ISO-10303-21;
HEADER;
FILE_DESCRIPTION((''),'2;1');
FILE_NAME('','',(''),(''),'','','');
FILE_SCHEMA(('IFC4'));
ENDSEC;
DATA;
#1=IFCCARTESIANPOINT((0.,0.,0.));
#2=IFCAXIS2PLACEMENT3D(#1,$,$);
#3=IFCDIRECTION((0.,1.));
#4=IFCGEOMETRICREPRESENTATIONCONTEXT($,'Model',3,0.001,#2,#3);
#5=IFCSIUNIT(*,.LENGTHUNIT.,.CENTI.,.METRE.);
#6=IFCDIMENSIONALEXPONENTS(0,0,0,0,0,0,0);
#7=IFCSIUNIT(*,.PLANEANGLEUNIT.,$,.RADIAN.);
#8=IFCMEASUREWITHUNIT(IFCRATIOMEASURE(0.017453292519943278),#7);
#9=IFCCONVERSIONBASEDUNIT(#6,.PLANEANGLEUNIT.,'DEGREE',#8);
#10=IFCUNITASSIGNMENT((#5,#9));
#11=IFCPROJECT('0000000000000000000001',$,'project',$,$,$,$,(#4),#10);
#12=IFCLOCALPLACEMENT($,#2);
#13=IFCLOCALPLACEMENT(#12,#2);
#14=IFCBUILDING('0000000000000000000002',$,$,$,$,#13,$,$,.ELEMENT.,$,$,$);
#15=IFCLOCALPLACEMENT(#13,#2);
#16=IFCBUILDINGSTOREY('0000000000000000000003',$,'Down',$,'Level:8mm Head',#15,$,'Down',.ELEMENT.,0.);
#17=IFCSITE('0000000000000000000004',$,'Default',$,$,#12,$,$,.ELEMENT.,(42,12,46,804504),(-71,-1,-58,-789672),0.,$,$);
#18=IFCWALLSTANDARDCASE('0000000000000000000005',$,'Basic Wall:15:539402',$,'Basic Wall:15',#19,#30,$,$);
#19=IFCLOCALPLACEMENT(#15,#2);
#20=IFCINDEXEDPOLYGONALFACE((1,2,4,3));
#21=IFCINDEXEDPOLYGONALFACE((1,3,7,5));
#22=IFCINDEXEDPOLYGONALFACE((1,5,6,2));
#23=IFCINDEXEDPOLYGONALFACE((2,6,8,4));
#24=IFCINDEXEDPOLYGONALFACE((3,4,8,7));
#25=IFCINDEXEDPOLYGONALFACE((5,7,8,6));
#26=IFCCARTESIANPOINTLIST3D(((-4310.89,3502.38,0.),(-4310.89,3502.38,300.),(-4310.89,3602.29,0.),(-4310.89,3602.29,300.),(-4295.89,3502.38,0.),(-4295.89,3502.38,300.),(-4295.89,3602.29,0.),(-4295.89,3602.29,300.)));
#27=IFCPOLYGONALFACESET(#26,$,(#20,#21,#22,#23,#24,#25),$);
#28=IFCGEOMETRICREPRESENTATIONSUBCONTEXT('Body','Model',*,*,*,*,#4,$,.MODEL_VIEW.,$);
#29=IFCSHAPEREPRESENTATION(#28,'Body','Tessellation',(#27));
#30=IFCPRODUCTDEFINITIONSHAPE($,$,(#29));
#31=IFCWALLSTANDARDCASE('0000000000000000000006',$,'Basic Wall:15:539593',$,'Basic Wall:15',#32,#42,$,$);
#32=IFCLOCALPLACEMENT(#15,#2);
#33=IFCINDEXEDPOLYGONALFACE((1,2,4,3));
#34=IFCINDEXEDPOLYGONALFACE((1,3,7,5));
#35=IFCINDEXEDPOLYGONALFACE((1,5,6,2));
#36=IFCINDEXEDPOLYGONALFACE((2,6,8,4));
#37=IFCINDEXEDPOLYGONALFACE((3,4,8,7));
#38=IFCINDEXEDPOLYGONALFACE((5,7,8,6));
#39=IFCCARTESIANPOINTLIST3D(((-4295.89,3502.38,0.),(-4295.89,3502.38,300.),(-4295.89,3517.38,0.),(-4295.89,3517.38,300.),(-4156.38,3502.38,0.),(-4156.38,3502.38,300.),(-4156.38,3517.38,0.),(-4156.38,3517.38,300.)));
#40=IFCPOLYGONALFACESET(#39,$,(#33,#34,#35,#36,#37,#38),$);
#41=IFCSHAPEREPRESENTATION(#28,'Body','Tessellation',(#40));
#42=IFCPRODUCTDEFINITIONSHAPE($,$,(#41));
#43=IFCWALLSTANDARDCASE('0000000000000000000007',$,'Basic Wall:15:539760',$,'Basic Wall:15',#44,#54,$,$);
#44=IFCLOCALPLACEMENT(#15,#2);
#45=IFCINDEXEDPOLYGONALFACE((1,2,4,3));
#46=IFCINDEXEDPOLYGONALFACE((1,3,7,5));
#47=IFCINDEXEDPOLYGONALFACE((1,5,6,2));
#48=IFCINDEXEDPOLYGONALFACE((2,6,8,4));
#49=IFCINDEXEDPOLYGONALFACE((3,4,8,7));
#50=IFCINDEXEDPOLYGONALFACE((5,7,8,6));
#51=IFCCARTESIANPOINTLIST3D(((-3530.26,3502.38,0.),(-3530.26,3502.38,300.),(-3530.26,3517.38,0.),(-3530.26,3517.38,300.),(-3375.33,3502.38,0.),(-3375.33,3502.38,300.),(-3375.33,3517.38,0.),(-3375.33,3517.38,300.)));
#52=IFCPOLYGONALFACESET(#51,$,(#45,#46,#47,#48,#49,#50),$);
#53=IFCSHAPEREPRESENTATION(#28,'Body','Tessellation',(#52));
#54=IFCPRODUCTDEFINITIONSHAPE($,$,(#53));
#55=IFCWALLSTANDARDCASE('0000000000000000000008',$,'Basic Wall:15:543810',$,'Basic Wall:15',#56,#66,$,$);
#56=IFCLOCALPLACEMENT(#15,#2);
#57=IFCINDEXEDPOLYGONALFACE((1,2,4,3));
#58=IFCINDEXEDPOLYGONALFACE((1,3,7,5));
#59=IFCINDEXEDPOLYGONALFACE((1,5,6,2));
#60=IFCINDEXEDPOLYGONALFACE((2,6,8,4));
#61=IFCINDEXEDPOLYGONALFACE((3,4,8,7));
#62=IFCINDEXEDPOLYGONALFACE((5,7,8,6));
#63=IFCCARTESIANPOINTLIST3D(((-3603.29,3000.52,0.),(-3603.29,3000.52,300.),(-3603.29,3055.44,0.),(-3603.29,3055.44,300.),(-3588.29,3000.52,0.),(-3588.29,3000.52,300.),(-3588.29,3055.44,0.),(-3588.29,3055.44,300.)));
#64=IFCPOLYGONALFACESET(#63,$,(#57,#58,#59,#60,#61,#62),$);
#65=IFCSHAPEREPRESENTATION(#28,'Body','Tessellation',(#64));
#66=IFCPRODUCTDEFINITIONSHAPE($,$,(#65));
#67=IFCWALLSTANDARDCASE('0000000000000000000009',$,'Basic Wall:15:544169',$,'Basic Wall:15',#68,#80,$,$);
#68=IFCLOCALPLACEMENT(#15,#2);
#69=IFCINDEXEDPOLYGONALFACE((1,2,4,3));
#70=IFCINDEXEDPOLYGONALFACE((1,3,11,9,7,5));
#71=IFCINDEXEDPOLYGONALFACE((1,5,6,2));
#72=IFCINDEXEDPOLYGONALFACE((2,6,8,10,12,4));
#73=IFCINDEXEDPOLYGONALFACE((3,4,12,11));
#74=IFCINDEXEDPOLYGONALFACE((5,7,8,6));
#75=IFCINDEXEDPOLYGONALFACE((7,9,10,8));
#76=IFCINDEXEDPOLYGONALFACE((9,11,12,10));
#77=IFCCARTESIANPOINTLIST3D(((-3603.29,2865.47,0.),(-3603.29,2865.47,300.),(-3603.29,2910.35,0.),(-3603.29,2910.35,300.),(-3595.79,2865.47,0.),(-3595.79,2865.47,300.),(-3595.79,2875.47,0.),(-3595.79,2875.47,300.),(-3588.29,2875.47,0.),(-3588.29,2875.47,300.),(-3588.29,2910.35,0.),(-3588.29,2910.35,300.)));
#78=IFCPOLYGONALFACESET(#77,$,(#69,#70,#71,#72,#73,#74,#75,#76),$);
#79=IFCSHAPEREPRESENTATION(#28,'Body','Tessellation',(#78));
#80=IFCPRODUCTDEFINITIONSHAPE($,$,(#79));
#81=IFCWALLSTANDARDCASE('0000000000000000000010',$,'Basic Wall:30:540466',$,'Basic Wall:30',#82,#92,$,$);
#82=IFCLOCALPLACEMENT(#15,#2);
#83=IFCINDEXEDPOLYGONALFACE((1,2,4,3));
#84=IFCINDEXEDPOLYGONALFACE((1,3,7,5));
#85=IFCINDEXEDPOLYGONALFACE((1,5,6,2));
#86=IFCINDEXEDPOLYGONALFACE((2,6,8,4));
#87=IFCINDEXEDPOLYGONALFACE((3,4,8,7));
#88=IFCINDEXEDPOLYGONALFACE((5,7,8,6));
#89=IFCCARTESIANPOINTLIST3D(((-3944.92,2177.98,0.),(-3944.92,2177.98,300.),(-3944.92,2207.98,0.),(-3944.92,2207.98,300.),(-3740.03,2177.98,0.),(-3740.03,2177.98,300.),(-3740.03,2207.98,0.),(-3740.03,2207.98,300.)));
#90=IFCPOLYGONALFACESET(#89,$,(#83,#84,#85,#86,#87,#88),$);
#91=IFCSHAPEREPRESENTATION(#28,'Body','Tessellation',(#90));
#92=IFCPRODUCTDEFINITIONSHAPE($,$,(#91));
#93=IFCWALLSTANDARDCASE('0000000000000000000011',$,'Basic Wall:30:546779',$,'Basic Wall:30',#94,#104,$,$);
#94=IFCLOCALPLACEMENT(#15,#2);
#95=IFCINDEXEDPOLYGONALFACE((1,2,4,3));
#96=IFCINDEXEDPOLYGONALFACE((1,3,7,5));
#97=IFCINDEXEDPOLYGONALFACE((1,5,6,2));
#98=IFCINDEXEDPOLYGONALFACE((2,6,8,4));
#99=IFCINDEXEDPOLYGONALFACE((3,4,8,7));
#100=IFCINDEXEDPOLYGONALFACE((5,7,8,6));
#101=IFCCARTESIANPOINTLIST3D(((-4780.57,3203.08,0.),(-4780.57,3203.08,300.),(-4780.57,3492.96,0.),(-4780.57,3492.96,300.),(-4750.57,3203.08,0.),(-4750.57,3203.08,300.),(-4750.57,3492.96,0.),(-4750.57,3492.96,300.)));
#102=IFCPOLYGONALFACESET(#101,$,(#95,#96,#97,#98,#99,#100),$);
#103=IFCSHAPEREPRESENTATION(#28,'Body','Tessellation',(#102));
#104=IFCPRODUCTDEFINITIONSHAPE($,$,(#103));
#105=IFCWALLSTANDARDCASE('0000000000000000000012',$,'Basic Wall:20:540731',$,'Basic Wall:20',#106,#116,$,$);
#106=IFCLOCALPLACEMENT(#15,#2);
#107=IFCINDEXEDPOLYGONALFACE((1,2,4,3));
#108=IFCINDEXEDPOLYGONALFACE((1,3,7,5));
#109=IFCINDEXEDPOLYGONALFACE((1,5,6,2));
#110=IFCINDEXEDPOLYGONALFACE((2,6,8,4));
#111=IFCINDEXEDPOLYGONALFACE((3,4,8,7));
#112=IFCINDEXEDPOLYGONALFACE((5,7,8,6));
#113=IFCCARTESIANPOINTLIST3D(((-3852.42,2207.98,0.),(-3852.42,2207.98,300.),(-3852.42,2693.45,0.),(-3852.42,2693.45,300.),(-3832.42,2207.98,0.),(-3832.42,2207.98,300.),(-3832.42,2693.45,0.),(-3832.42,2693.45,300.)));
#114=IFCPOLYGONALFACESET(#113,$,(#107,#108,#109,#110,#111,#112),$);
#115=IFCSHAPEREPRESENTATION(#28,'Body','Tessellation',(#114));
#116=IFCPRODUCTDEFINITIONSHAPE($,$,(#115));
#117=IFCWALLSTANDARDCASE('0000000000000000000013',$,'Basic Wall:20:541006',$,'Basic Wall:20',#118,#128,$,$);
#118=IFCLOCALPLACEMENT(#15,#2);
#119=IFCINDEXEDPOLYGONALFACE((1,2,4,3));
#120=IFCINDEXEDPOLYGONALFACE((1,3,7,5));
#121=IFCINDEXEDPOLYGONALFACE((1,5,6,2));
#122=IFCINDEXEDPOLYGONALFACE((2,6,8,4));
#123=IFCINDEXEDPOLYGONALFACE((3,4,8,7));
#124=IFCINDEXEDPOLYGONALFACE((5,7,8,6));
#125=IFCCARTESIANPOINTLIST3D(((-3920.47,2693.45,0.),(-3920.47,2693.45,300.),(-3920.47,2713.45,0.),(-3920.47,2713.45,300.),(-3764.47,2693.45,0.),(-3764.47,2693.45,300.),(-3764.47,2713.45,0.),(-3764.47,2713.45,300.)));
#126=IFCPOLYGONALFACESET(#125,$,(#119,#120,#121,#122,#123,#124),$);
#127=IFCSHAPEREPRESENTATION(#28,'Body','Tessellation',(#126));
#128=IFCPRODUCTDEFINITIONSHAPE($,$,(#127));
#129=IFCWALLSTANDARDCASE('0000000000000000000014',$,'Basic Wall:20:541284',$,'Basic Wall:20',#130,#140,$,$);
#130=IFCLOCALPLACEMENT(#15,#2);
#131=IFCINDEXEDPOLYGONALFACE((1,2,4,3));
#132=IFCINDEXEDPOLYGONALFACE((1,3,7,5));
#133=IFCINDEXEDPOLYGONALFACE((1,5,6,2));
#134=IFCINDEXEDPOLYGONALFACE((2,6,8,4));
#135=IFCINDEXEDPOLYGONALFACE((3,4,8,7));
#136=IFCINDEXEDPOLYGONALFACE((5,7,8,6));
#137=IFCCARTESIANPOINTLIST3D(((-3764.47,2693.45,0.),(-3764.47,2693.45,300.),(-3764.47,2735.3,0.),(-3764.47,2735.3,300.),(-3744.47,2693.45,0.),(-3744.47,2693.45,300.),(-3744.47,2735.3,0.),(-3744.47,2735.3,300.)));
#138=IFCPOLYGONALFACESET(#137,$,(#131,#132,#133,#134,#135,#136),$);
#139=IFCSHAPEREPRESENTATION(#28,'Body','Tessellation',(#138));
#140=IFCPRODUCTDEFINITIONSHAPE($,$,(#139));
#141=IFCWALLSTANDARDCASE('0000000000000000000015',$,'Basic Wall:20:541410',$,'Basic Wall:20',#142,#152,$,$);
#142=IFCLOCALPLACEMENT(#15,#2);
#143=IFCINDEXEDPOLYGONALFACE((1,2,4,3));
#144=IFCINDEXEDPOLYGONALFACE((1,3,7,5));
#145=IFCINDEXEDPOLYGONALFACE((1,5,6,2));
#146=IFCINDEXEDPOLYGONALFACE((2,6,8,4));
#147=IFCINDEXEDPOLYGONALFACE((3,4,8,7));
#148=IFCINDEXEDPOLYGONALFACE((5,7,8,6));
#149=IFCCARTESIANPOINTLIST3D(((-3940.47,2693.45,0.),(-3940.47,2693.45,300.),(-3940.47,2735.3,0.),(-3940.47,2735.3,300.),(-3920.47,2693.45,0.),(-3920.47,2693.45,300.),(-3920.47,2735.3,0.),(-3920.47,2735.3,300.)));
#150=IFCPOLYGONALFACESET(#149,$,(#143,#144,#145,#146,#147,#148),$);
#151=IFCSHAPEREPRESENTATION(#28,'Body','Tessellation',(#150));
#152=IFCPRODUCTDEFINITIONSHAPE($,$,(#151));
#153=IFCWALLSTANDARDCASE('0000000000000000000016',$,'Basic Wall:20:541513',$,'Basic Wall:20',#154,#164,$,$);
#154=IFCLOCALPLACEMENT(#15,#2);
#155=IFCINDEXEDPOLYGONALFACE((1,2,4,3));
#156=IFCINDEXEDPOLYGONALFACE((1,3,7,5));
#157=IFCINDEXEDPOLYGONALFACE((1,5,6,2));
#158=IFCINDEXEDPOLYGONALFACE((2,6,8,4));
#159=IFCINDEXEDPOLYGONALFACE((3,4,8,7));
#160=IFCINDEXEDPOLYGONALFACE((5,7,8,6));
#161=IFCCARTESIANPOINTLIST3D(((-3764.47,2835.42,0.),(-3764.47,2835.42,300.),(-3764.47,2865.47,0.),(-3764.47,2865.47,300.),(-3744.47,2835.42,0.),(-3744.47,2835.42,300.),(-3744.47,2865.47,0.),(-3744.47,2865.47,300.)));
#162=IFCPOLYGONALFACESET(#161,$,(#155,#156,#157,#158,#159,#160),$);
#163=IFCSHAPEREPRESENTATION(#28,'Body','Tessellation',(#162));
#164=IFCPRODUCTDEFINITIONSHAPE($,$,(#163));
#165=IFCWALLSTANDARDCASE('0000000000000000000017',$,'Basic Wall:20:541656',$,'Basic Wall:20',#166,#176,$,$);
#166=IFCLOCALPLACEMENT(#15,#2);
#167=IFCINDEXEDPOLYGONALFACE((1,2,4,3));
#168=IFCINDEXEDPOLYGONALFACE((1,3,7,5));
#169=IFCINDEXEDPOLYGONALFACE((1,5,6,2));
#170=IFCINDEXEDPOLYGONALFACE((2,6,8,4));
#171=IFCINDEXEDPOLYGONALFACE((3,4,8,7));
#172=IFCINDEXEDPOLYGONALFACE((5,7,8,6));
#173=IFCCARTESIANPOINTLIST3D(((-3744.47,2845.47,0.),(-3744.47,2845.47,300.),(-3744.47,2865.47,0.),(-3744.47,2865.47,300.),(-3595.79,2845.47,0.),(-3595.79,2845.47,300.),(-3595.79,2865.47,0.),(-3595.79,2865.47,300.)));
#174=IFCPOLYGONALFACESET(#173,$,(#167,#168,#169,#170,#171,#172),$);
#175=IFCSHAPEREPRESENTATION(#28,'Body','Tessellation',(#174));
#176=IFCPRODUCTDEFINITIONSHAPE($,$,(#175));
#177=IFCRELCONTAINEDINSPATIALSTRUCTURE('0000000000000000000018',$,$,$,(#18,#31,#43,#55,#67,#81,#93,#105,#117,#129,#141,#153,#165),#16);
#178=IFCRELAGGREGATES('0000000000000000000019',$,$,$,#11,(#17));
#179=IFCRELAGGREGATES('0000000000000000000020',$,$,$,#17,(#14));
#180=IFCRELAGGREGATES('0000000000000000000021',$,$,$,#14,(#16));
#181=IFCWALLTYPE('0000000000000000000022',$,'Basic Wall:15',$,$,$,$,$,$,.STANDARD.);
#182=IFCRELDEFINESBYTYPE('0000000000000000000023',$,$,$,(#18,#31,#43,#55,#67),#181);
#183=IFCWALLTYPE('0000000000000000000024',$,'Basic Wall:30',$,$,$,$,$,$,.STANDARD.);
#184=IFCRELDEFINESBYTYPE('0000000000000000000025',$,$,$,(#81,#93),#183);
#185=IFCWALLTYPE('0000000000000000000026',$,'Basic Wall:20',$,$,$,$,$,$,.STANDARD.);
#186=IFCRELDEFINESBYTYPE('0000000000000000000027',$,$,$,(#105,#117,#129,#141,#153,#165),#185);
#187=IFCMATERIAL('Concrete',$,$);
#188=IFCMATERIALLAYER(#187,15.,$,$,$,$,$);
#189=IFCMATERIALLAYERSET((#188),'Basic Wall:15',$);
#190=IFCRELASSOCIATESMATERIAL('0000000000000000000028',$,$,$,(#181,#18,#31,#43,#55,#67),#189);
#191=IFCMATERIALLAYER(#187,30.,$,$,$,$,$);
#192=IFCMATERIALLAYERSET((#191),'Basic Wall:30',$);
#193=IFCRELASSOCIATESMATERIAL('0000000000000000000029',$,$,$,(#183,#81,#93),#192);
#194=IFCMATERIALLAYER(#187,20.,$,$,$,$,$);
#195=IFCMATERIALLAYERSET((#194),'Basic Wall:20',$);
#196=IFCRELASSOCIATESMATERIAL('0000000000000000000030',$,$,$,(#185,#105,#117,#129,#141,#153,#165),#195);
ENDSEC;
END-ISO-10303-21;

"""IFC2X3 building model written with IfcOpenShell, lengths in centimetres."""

from ifc_helpers import new_model, entity, si_unit, converted_unit, direction, frame, frame_2d, origin, place, context, subcontext, project, spatial, polyline, rectangle, outline, extrude, material, layer, layer_set, layer_usage, type_object, element, save


model = new_model("IFC2X3")

# Units and contexts
model_context = context("Model", 3, precision=0.001, world=origin(), true_north=direction((0.0, 1.0)))
body_context = subcontext(model_context, "Body", "Model", "MODEL_VIEW")
ifc_project = project(units=[si_unit("LENGTHUNIT", "METRE", prefix="CENTI"), converted_unit("PLANEANGLEUNIT", "DEGREE", entity("IfcRatioMeasure", 0.017453292519943278), si_unit("PLANEANGLEUNIT", "RADIAN"), dimensions=[0, 0, 0, 0, 0, 0, 0])], contexts=[model_context])

# Site, building, storey
site_placement = place(None, origin())
site = spatial("IfcSite", under=ifc_project, at=site_placement, Name="Default", CompositionType="ELEMENT", RefLatitude=(42, 12, 46, 804504), RefLongitude=(-71, -1, -58, -789672), RefElevation=0.0)
building_placement = place(site_placement, origin())
building = spatial("IfcBuilding", under=site, at=building_placement, CompositionType="ELEMENT")
storey_placement = place(building_placement, origin())
storey = spatial("IfcBuildingStorey", under=building, at=storey_placement, Name="Down", ObjectType="Level:8mm Head", LongName="Down", CompositionType="ELEMENT", Elevation=0.0)

# Walls
ifc_material = material(Name="Concrete")
ifc_layer_1 = layer(ifc_material, 15.0)
ifc_layer_set_1 = layer_set([ifc_layer_1], Name="Basic Wall:15")
ifc_layer_usage_1 = layer_usage(ifc_layer_set_1, "AXIS2", "POSITIVE", -7.5)
wall_type_1 = type_object("IfcWallType", Name="Basic Wall:15", PredefinedType="STANDARD", material=ifc_layer_set_1)
wall_1_placement = place(storey_placement, frame((-4303.39, 3602.29, 0.0), z_axis=(0.0, 0.0, 1.0), x_axis=(0.0, -1.0, 0.0)))
element("IfcWallStandardCase", 1, at=wall_1_placement, inside=storey, type_object=wall_type_1, material=ifc_layer_usage_1, Name="Basic Wall:15:539402", ObjectType="Basic Wall:15", context=body_context, shape_type="SweptSolid", body=[
    extrude(rectangle(XDim=99.91, YDim=15.0, at=frame_2d((49.95, 0.0), x_axis=(-1.0, 0.0))), origin(), (0.0, 0.0, 1.0), 300.0),
])
ifc_layer_usage_2 = layer_usage(ifc_layer_set_1, "AXIS2", "POSITIVE", -7.5)
wall_2_placement = place(storey_placement, frame((-4295.89, 3509.88, 0.0)))
element("IfcWallStandardCase", 2, at=wall_2_placement, inside=storey, type_object=wall_type_1, material=ifc_layer_usage_2, Name="Basic Wall:15:539593", ObjectType="Basic Wall:15", context=body_context, shape_type="SweptSolid", body=[
    extrude(rectangle(XDim=139.51, YDim=15.0, at=frame_2d((69.76, 0.0), x_axis=(-1.0, 0.0))), origin(), (0.0, 0.0, 1.0), 300.0),
])
ifc_layer_usage_3 = layer_usage(ifc_layer_set_1, "AXIS2", "POSITIVE", -7.5)
wall_3_placement = place(storey_placement, frame((-3530.26, 3509.88, 0.0)))
element("IfcWallStandardCase", 3, at=wall_3_placement, inside=storey, type_object=wall_type_1, material=ifc_layer_usage_3, Name="Basic Wall:15:539760", ObjectType="Basic Wall:15", context=body_context, shape_type="SweptSolid", body=[
    extrude(rectangle(XDim=154.94, YDim=15.0, at=frame_2d((77.47, 0.0), x_axis=(-1.0, 0.0))), origin(), (0.0, 0.0, 1.0), 300.0),
])
ifc_layer_usage_4 = layer_usage(ifc_layer_set_1, "AXIS2", "POSITIVE", -7.5)
wall_4_placement = place(storey_placement, frame((-3595.79, 3055.44, 0.0), z_axis=(0.0, 0.0, 1.0), x_axis=(0.0, -1.0, 0.0)))
element("IfcWallStandardCase", 4, at=wall_4_placement, inside=storey, type_object=wall_type_1, material=ifc_layer_usage_4, Name="Basic Wall:15:543810", ObjectType="Basic Wall:15", context=body_context, shape_type="SweptSolid", body=[
    extrude(rectangle(XDim=54.93, YDim=15.0, at=frame_2d((27.46, 0.0), x_axis=(-1.0, 0.0))), origin(), (0.0, 0.0, 1.0), 300.0),
])
ifc_layer_usage_5 = layer_usage(ifc_layer_set_1, "AXIS2", "POSITIVE", -7.5)
wall_5_placement = place(storey_placement, frame((-3595.79, 2910.35, 0.0), z_axis=(0.0, 0.0, 1.0), x_axis=(0.0, -1.0, 0.0)))
element("IfcWallStandardCase", 5, at=wall_5_placement, inside=storey, type_object=wall_type_1, material=ifc_layer_usage_5, Name="Basic Wall:15:544169", ObjectType="Basic Wall:15", context=body_context, shape_type="SweptSolid", body=[
    extrude(outline(polyline([(44.87, -7.5), (44.87, 0.0), (34.87, 0.0), (34.87, 7.5), (0.0, 7.5), (0.0, -7.5), (44.87, -7.5)])), origin(), (0.0, 0.0, 1.0), 300.0),
])
ifc_layer_2 = layer(ifc_material, 30.0)
ifc_layer_set_2 = layer_set([ifc_layer_2], Name="Basic Wall:30")
ifc_layer_usage_6 = layer_usage(ifc_layer_set_2, "AXIS2", "POSITIVE", -15.0)
wall_type_2 = type_object("IfcWallType", Name="Basic Wall:30", PredefinedType="STANDARD", material=ifc_layer_set_2)
wall_6_placement = place(storey_placement, frame((-3944.92, 2192.98, 0.0)))
element("IfcWallStandardCase", 6, at=wall_6_placement, inside=storey, type_object=wall_type_2, material=ifc_layer_usage_6, Name="Basic Wall:30:540466", ObjectType="Basic Wall:30", context=body_context, shape_type="SweptSolid", body=[
    extrude(rectangle(XDim=204.89, YDim=30.0, at=frame_2d((102.45, 0.0), x_axis=(-1.0, 0.0))), origin(), (0.0, 0.0, 1.0), 300.0),
])
ifc_layer_usage_7 = layer_usage(ifc_layer_set_2, "AXIS2", "POSITIVE", -15.0)
wall_7_placement = place(storey_placement, frame((-4765.57, 3492.96, 0.0), z_axis=(0.0, 0.0, 1.0), x_axis=(0.0, -1.0, 0.0)))
element("IfcWallStandardCase", 7, at=wall_7_placement, inside=storey, type_object=wall_type_2, material=ifc_layer_usage_7, Name="Basic Wall:30:546779", ObjectType="Basic Wall:30", context=body_context, shape_type="SweptSolid", body=[
    extrude(rectangle(XDim=289.88, YDim=30.0, at=frame_2d((144.94, 0.0), x_axis=(-1.0, 0.0))), origin(), (0.0, 0.0, 1.0), 300.0),
])
ifc_layer_3 = layer(ifc_material, 20.0)
ifc_layer_set_3 = layer_set([ifc_layer_3], Name="Basic Wall:20")
ifc_layer_usage_8 = layer_usage(ifc_layer_set_3, "AXIS2", "NEGATIVE", 10.0)
wall_type_3 = type_object("IfcWallType", Name="Basic Wall:20", PredefinedType="STANDARD", material=ifc_layer_set_3)
wall_8_placement = place(storey_placement, frame((-3842.42, 2207.98, 0.0), z_axis=(0.0, 0.0, 1.0), x_axis=(0.0, 1.0, 0.0)))
element("IfcWallStandardCase", 8, at=wall_8_placement, inside=storey, type_object=wall_type_3, material=ifc_layer_usage_8, Name="Basic Wall:20:540731", ObjectType="Basic Wall:20", context=body_context, shape_type="SweptSolid", body=[
    extrude(rectangle(XDim=485.47, YDim=20.0, at=frame_2d((242.74, 0.0), x_axis=(-1.0, 0.0))), origin(), (0.0, 0.0, 1.0), 300.0),
])
ifc_layer_usage_9 = layer_usage(ifc_layer_set_3, "AXIS2", "POSITIVE", -10.0)
wall_9_placement = place(storey_placement, frame((-3920.47, 2703.45, 0.0)))
element("IfcWallStandardCase", 9, at=wall_9_placement, inside=storey, type_object=wall_type_3, material=ifc_layer_usage_9, Name="Basic Wall:20:541006", ObjectType="Basic Wall:20", context=body_context, shape_type="SweptSolid", body=[
    extrude(rectangle(XDim=156.0, YDim=20.0, at=frame_2d((78.0, 0.0), x_axis=(-1.0, 0.0))), origin(), (0.0, 0.0, 1.0), 300.0),
])
ifc_layer_usage_10 = layer_usage(ifc_layer_set_3, "AXIS2", "POSITIVE", -10.0)
wall_10_placement = place(storey_placement, frame((-3754.47, 2693.45, 0.0), z_axis=(0.0, 0.0, 1.0), x_axis=(0.0, 1.0, 0.0)))
element("IfcWallStandardCase", 10, at=wall_10_placement, inside=storey, type_object=wall_type_3, material=ifc_layer_usage_10, Name="Basic Wall:20:541284", ObjectType="Basic Wall:20", context=body_context, shape_type="SweptSolid", body=[
    extrude(rectangle(XDim=41.85, YDim=20.0, at=frame_2d((20.92, 0.0), x_axis=(-1.0, 0.0))), origin(), (0.0, 0.0, 1.0), 300.0),
])
ifc_layer_usage_11 = layer_usage(ifc_layer_set_3, "AXIS2", "NEGATIVE", 10.0)
wall_11_placement = place(storey_placement, frame((-3930.47, 2693.45, 0.0), z_axis=(0.0, 0.0, 1.0), x_axis=(0.0, 1.0, 0.0)))
element("IfcWallStandardCase", 11, at=wall_11_placement, inside=storey, type_object=wall_type_3, material=ifc_layer_usage_11, Name="Basic Wall:20:541410", ObjectType="Basic Wall:20", context=body_context, shape_type="SweptSolid", body=[
    extrude(rectangle(XDim=41.85, YDim=20.0, at=frame_2d((20.92, 0.0), x_axis=(-1.0, 0.0))), origin(), (0.0, 0.0, 1.0), 300.0),
])
ifc_layer_usage_12 = layer_usage(ifc_layer_set_3, "AXIS2", "NEGATIVE", 10.0)
wall_12_placement = place(storey_placement, frame((-3754.47, 2835.42, 0.0), z_axis=(0.0, 0.0, 1.0), x_axis=(0.0, 1.0, 0.0)))
element("IfcWallStandardCase", 12, at=wall_12_placement, inside=storey, type_object=wall_type_3, material=ifc_layer_usage_12, Name="Basic Wall:20:541513", ObjectType="Basic Wall:20", context=body_context, shape_type="SweptSolid", body=[
    extrude(rectangle(XDim=30.05, YDim=20.0, at=frame_2d((15.03, 0.0), x_axis=(-1.0, 0.0))), origin(), (0.0, 0.0, 1.0), 300.0),
])
ifc_layer_usage_13 = layer_usage(ifc_layer_set_3, "AXIS2", "NEGATIVE", 10.0)
wall_13_placement = place(storey_placement, frame((-3744.47, 2855.47, 0.0)))
element("IfcWallStandardCase", 13, at=wall_13_placement, inside=storey, type_object=wall_type_3, material=ifc_layer_usage_13, Name="Basic Wall:20:541656", ObjectType="Basic Wall:20", context=body_context, shape_type="SweptSolid", body=[
    extrude(rectangle(XDim=148.68, YDim=20.0, at=frame_2d((74.34, 0.0), x_axis=(-1.0, 0.0))), origin(), (0.0, 0.0, 1.0), 300.0),
])

save(model, "model.ifc")
